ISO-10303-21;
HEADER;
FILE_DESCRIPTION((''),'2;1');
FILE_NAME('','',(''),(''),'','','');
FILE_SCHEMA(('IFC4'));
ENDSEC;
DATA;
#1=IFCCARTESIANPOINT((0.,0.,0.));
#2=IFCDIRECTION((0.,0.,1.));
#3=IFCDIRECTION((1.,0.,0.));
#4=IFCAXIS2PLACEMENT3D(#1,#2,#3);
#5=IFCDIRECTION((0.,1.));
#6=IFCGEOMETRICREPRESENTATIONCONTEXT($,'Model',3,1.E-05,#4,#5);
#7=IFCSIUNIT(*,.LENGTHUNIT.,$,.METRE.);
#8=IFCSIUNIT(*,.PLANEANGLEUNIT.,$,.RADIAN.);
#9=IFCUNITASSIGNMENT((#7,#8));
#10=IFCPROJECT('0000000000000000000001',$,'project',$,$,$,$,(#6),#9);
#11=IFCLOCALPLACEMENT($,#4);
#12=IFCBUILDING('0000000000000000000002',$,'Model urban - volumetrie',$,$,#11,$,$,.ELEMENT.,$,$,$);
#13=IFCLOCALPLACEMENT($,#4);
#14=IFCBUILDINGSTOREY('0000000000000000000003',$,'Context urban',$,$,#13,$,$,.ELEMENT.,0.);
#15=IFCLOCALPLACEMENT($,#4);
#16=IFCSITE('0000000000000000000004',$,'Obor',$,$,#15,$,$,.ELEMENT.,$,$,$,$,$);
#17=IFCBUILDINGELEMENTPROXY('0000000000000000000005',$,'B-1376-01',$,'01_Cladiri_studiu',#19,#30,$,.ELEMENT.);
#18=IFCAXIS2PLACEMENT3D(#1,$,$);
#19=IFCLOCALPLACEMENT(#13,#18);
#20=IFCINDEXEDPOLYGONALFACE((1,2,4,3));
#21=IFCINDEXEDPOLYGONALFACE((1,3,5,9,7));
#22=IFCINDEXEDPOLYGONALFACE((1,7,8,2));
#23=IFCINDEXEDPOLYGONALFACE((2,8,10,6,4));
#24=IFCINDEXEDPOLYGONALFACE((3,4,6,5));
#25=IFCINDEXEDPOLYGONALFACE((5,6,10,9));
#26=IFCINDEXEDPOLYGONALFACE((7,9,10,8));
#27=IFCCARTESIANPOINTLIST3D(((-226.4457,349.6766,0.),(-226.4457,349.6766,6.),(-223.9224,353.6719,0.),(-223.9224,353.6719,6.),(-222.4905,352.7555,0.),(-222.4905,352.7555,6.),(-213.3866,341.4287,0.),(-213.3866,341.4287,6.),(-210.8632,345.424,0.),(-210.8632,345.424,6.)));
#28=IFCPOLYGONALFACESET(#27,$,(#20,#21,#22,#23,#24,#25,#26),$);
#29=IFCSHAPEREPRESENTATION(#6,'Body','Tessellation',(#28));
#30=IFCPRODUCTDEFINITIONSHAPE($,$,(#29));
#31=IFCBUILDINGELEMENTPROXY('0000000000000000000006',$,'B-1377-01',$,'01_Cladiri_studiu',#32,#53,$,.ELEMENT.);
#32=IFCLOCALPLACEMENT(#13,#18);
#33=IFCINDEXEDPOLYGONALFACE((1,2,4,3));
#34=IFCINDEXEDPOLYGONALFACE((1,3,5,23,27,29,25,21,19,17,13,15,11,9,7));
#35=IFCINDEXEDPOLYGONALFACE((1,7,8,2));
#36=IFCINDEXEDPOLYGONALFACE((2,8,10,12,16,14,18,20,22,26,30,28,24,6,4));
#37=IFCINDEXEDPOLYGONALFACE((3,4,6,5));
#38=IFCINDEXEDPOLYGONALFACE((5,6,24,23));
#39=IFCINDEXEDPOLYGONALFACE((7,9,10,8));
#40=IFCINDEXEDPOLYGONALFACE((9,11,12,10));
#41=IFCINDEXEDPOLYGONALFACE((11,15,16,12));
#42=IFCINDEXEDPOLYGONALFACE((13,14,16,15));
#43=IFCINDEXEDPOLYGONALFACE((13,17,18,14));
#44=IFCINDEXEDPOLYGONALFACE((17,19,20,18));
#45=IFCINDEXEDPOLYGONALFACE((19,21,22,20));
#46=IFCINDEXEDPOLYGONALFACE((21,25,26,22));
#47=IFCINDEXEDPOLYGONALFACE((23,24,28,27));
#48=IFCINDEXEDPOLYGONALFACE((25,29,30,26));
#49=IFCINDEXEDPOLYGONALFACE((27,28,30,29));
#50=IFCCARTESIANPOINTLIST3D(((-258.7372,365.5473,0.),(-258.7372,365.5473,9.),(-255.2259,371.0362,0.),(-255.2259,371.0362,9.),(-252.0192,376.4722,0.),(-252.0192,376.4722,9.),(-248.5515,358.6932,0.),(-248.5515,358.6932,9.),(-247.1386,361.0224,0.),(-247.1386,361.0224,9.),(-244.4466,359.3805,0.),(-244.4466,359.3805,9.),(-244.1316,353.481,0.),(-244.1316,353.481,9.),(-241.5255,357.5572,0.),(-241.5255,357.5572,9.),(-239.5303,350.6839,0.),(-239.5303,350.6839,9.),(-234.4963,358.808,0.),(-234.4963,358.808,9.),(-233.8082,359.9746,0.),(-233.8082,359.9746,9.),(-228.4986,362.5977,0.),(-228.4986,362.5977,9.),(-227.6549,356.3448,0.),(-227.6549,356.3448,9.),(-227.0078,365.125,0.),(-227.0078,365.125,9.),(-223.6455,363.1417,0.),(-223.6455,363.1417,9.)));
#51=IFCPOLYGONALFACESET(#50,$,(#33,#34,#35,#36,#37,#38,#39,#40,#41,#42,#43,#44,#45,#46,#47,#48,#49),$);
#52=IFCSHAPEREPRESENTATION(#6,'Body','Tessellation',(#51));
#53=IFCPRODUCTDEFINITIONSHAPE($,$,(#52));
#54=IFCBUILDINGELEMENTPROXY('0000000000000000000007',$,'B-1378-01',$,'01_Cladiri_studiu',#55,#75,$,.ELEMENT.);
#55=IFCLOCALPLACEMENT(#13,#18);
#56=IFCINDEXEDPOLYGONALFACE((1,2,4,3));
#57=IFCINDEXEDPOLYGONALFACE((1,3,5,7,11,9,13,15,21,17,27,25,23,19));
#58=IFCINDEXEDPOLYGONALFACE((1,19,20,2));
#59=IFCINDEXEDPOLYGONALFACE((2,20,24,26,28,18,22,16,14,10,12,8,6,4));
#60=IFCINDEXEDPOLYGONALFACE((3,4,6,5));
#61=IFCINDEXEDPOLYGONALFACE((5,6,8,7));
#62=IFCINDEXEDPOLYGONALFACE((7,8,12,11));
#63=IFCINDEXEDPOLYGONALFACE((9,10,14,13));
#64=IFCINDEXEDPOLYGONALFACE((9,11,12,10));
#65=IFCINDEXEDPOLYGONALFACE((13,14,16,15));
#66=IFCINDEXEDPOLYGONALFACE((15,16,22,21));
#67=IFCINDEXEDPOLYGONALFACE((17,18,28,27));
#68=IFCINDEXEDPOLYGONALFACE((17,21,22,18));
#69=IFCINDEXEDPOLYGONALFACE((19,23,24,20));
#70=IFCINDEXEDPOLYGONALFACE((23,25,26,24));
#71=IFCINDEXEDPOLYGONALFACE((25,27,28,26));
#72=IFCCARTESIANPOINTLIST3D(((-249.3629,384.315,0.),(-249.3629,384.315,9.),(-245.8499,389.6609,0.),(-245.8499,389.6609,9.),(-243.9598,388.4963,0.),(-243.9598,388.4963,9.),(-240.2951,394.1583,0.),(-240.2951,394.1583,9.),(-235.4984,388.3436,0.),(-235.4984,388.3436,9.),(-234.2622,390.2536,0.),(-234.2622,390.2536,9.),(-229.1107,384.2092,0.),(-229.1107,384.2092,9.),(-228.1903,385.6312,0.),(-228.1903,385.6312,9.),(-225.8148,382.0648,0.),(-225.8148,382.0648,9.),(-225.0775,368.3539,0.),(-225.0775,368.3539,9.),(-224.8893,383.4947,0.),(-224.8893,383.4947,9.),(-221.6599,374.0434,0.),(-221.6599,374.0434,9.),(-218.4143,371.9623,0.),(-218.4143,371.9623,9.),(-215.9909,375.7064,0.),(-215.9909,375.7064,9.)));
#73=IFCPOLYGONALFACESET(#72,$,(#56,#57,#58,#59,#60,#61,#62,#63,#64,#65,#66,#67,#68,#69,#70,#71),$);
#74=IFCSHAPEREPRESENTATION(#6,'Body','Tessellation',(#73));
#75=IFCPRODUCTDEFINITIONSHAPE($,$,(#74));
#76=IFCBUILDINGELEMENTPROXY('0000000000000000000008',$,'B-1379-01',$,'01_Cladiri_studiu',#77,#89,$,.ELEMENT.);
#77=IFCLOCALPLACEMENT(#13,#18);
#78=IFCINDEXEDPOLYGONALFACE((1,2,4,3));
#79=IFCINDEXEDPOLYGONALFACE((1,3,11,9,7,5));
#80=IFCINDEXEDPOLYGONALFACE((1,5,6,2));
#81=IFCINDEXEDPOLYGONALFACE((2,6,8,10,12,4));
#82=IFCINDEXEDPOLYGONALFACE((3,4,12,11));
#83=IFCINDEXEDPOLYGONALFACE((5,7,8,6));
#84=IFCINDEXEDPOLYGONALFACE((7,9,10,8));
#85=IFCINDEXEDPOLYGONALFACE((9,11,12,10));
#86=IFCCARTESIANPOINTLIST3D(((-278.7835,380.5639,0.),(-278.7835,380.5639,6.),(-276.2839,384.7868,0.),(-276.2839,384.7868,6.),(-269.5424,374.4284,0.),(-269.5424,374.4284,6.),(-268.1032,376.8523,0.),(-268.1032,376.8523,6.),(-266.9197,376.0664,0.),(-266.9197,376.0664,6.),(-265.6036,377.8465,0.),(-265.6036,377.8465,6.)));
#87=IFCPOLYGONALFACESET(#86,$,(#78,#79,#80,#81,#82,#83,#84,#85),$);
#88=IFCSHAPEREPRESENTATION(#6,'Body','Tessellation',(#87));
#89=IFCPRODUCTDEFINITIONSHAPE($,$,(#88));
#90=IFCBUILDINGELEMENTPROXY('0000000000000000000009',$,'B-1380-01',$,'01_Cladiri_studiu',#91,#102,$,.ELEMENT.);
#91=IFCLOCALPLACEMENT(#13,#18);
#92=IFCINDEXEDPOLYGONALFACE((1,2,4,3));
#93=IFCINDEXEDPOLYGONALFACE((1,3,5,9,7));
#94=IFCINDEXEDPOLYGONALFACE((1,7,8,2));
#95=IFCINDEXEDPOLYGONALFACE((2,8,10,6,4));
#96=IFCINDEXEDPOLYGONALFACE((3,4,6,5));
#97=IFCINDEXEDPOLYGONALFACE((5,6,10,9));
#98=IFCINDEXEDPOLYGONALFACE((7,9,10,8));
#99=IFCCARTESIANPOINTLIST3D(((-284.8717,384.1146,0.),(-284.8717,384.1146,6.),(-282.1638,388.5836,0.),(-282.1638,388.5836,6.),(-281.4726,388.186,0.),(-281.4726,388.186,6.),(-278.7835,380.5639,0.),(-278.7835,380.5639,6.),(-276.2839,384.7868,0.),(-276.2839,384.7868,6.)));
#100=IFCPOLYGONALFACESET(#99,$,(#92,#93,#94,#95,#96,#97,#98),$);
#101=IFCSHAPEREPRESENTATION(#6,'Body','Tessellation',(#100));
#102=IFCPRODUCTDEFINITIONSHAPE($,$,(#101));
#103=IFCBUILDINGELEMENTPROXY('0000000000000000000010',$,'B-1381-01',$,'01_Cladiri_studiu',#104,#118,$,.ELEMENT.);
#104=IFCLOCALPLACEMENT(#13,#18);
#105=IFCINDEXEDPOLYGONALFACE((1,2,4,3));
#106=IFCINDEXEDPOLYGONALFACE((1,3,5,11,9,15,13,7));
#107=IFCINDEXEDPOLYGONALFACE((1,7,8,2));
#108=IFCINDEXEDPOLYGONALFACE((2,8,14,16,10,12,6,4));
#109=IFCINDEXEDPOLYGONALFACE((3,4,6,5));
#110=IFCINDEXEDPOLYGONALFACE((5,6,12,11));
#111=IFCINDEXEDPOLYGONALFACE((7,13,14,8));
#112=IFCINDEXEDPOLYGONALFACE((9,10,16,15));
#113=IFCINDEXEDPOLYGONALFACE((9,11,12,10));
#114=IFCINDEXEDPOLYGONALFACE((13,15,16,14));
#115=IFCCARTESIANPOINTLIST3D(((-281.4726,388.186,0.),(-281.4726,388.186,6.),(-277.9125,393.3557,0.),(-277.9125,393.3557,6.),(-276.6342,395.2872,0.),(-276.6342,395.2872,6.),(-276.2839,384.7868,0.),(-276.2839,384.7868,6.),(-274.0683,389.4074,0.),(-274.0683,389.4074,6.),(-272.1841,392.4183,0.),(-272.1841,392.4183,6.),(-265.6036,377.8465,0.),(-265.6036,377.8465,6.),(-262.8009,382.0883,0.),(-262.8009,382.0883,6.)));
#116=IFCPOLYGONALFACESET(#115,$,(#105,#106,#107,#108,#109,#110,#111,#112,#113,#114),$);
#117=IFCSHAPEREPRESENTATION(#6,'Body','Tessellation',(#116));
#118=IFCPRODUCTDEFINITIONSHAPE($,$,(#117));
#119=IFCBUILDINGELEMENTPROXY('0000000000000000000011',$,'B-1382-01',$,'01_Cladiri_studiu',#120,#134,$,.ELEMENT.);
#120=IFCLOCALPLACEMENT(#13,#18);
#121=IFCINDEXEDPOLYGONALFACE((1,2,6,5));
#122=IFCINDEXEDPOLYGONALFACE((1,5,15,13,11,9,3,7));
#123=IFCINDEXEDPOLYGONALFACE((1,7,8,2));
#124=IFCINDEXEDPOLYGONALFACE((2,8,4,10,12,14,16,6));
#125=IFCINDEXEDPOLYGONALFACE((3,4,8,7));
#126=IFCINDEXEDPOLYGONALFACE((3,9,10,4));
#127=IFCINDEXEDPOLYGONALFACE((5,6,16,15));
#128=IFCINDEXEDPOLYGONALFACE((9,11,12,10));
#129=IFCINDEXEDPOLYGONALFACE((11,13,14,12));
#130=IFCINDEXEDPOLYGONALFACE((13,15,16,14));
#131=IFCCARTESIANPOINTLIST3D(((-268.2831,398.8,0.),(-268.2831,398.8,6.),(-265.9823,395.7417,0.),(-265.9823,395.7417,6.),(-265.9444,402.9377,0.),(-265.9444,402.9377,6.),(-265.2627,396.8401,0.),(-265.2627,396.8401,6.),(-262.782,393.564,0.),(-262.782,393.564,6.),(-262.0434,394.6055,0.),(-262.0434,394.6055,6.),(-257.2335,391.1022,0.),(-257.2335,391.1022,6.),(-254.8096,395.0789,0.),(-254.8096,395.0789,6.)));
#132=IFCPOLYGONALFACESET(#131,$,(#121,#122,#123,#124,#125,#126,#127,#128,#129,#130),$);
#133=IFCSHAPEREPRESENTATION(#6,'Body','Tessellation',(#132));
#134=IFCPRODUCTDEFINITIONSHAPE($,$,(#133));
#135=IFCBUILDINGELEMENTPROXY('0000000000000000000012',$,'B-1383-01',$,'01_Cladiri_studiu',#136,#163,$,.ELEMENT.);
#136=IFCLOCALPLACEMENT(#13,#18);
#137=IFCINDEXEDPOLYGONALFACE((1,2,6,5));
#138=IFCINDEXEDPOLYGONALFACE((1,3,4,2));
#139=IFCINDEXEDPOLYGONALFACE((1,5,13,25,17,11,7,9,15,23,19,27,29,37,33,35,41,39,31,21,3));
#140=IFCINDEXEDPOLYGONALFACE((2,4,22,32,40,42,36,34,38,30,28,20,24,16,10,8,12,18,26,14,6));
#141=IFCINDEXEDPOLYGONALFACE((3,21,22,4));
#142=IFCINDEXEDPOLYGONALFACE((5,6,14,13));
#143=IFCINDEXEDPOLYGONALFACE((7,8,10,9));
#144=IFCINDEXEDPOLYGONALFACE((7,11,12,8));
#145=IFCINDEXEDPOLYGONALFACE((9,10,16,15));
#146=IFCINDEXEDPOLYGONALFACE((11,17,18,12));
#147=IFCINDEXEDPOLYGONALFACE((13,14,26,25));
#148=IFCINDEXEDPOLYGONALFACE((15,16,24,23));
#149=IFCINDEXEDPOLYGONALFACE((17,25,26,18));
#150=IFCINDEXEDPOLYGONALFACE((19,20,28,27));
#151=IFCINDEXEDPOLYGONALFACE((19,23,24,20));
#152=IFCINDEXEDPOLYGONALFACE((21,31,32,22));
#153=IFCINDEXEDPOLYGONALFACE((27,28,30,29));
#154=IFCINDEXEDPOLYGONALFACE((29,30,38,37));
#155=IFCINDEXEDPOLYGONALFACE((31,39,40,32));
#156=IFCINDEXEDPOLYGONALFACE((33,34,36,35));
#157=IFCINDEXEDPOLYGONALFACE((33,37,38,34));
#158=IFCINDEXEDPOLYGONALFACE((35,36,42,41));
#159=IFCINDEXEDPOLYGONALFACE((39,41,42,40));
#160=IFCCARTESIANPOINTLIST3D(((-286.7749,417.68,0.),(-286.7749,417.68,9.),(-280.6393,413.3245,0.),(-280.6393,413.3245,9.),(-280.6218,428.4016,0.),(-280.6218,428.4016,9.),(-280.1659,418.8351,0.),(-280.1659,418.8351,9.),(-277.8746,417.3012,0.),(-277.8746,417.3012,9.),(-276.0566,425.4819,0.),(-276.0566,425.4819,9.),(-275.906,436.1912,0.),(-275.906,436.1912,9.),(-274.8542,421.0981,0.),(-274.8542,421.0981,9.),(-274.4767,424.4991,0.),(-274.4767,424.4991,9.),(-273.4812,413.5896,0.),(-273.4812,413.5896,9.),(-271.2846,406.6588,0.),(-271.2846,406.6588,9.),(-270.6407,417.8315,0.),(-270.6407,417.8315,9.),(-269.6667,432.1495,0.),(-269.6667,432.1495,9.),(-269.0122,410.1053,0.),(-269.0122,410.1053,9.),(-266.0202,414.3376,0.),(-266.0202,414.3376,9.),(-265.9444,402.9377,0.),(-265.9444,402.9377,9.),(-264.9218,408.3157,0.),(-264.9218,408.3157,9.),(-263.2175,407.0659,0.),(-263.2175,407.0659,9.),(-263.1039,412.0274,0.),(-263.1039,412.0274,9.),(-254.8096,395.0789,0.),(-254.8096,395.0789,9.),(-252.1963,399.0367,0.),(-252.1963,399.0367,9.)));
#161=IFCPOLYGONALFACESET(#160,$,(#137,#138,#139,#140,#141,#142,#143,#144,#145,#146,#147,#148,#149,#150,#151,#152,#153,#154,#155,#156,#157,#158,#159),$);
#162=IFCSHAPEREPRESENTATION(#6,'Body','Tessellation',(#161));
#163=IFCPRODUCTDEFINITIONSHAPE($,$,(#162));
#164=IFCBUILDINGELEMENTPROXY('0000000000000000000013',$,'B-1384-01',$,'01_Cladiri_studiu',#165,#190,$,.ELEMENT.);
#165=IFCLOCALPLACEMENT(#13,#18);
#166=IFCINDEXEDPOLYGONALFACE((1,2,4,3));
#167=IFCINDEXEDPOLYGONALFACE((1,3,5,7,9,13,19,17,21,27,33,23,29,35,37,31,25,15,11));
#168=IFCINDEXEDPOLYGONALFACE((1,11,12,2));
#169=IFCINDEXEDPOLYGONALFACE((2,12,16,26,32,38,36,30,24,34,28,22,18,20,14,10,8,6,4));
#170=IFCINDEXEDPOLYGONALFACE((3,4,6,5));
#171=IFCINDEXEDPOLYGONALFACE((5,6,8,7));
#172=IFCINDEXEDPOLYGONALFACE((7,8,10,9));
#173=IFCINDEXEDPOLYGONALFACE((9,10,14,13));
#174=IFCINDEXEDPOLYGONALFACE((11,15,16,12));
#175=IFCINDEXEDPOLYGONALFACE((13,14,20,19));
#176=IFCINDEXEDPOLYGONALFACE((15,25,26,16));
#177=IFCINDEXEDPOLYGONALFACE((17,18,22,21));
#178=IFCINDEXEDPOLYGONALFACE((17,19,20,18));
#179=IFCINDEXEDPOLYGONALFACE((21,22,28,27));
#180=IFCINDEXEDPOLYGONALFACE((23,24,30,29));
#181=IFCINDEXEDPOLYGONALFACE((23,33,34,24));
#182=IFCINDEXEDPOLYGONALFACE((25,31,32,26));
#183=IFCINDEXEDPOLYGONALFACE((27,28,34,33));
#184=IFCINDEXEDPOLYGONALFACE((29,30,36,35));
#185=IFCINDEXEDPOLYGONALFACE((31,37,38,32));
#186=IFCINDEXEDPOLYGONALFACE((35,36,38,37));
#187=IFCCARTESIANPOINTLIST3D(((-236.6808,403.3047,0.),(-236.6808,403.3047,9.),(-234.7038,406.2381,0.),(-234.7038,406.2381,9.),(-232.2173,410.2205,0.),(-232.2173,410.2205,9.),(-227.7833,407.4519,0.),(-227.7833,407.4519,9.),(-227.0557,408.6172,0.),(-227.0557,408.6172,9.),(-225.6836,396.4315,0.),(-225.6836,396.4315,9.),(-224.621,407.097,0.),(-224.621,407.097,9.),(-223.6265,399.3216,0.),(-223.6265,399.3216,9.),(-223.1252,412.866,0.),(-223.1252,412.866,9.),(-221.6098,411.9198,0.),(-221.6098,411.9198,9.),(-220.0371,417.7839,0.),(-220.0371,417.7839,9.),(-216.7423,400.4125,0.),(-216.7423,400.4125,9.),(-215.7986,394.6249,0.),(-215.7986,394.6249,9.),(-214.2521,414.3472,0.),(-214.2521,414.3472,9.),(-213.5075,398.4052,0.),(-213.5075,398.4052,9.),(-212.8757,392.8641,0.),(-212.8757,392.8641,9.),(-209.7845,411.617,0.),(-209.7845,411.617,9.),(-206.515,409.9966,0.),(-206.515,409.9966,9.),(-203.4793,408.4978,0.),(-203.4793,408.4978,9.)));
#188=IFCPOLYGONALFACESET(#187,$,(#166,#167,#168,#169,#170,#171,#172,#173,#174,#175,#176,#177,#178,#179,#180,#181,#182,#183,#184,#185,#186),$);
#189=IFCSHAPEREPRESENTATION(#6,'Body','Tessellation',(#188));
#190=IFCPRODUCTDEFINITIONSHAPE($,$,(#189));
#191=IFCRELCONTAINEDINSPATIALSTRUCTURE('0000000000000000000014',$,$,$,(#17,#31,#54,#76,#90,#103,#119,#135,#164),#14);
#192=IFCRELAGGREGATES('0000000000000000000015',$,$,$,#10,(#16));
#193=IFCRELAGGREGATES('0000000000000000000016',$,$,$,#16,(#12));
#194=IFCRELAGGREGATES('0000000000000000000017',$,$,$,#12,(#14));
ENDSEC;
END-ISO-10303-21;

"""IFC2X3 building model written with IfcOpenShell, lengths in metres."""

from ifc_helpers import new_model, si_unit, direction, origin_with_axes, place, context, project, spatial, polyline, outline, extrude, element, save


model = new_model("IFC2X3")

# Units and contexts
model_context = context("Model", 3, precision=1e-05, world=origin_with_axes(), true_north=direction((0.0, 1.0)))
ifc_project = project(units=[si_unit("LENGTHUNIT", "METRE"), si_unit("PLANEANGLEUNIT", "RADIAN")], contexts=[model_context])

# Site, building, storey
site_placement = place(None, origin_with_axes())
site = spatial("IfcSite", under=ifc_project, at=site_placement, Name="Obor", CompositionType="ELEMENT")
building_placement = place(None, origin_with_axes())
building = spatial("IfcBuilding", under=site, at=building_placement, Name="Model urban - volumetrie", CompositionType="ELEMENT")
storey_placement = place(None, origin_with_axes())
storey = spatial("IfcBuildingStorey", under=building, at=storey_placement, Name="Context urban", CompositionType="ELEMENT", Elevation=0.0)

# Building element proxies
proxy_1_placement = place(None, origin_with_axes())
element("IfcBuildingElementProxy", 1, at=proxy_1_placement, inside=storey, Name="B-1376-01", ObjectType="01_Cladiri_studiu", CompositionType="ELEMENT", context=model_context, shape_type="SweptSolid", body=[
    extrude(outline(polyline([(-226.4457, 349.6766), (-213.3866, 341.4287), (-210.8632, 345.424), (-222.4905, 352.7555), (-223.9224, 353.6719), (-226.4457, 349.6766)])), origin_with_axes(), (0.0, 0.0, 1.0), 6.0),
])
proxy_2_placement = place(None, origin_with_axes())
element("IfcBuildingElementProxy", 2, at=proxy_2_placement, inside=storey, Name="B-1377-01", ObjectType="01_Cladiri_studiu", CompositionType="ELEMENT", context=model_context, shape_type="SweptSolid", body=[
    extrude(outline(polyline([(-223.6455, 363.1417), (-227.0078, 365.125), (-228.4986, 362.5977), (-252.0192, 376.4722), (-255.2259, 371.0362), (-258.7372, 365.5473), (-248.5515, 358.6932), (-247.1386, 361.0224), (-244.4466, 359.3805), (-241.5255, 357.5572), (-244.1316, 353.481), (-239.5303, 350.6839), (-234.4963, 358.808), (-233.8082, 359.9746), (-227.6549, 356.3448), (-223.6455, 363.1417)]), holes=[polyline([(-246.2195, 365.7234), (-255.2259, 371.0362), (-246.2195, 365.7234), (-242.1078, 363.2753), (-246.2195, 365.7234)])]), origin_with_axes(), (0.0, 0.0, 1.0), 9.0),
])
proxy_3_placement = place(None, origin_with_axes())
element("IfcBuildingElementProxy", 3, at=proxy_3_placement, inside=storey, Name="B-1378-01", ObjectType="01_Cladiri_studiu", CompositionType="ELEMENT", context=model_context, shape_type="SweptSolid", body=[
    extrude(outline(polyline([(-225.8148, 382.0648), (-224.8893, 383.4947), (-228.1903, 385.6312), (-229.1107, 384.2092), (-235.4984, 388.3436), (-234.2622, 390.2536), (-240.2951, 394.1583), (-243.9598, 388.4963), (-245.8499, 389.6609), (-249.3629, 384.315), (-225.0775, 368.3539), (-221.6599, 374.0434), (-218.4143, 371.9623), (-215.9909, 375.7064), (-225.8148, 382.0648)])), origin_with_axes(), (0.0, 0.0, 1.0), 9.0),
])
proxy_4_placement = place(None, origin_with_axes())
element("IfcBuildingElementProxy", 4, at=proxy_4_placement, inside=storey, Name="B-1379-01", ObjectType="01_Cladiri_studiu", CompositionType="ELEMENT", context=model_context, shape_type="SweptSolid", body=[
    extrude(outline(polyline([(-266.9197, 376.0664), (-265.6036, 377.8465), (-276.2839, 384.7868), (-278.7835, 380.5639), (-269.5424, 374.4284), (-268.1032, 376.8523), (-266.9197, 376.0664)])), origin_with_axes(), (0.0, 0.0, 1.0), 6.0),
])
proxy_5_placement = place(None, origin_with_axes())
element("IfcBuildingElementProxy", 5, at=proxy_5_placement, inside=storey, Name="B-1380-01", ObjectType="01_Cladiri_studiu", CompositionType="ELEMENT", context=model_context, shape_type="SweptSolid", body=[
    extrude(outline(polyline([(-284.8717, 384.1146), (-278.7835, 380.5639), (-276.2839, 384.7868), (-281.4726, 388.186), (-282.1638, 388.5836), (-284.8717, 384.1146)])), origin_with_axes(), (0.0, 0.0, 1.0), 6.0),
])
proxy_6_placement = place(None, origin_with_axes())
element("IfcBuildingElementProxy", 6, at=proxy_6_placement, inside=storey, Name="B-1381-01", ObjectType="01_Cladiri_studiu", CompositionType="ELEMENT", context=model_context, shape_type="SweptSolid", body=[
    extrude(outline(polyline([(-281.4726, 388.186), (-276.2839, 384.7868), (-265.6036, 377.8465), (-262.8009, 382.0883), (-274.0683, 389.4074), (-272.1841, 392.4183), (-276.6342, 395.2872), (-277.9125, 393.3557), (-281.4726, 388.186)])), origin_with_axes(), (0.0, 0.0, 1.0), 6.0),
])
proxy_7_placement = place(None, origin_with_axes())
element("IfcBuildingElementProxy", 7, at=proxy_7_placement, inside=storey, Name="B-1382-01", ObjectType="01_Cladiri_studiu", CompositionType="ELEMENT", context=model_context, shape_type="SweptSolid", body=[
    extrude(outline(polyline([(-265.2627, 396.8401), (-265.9823, 395.7417), (-262.782, 393.564), (-262.0434, 394.6055), (-257.2335, 391.1022), (-254.8096, 395.0789), (-265.9444, 402.9377), (-268.2831, 398.8), (-265.2627, 396.8401)])), origin_with_axes(), (0.0, 0.0, 1.0), 6.0),
])
proxy_8_placement = place(None, origin_with_axes())
element("IfcBuildingElementProxy", 8, at=proxy_8_placement, inside=storey, Name="B-1383-01", ObjectType="01_Cladiri_studiu", CompositionType="ELEMENT", context=model_context, shape_type="SweptSolid", body=[
    extrude(outline(polyline([(-280.6218, 428.4016), (-286.7749, 417.68), (-280.6393, 413.3245), (-271.2846, 406.6588), (-265.9444, 402.9377), (-254.8096, 395.0789), (-252.1963, 399.0367), (-263.2175, 407.0659), (-264.9218, 408.3157), (-263.1039, 412.0274), (-266.0202, 414.3376), (-269.0122, 410.1053), (-273.4812, 413.5896), (-270.6407, 417.8315), (-274.8542, 421.0981), (-277.8746, 417.3012), (-280.1659, 418.8351), (-276.0566, 425.4819), (-274.4767, 424.4991), (-269.6667, 432.1495), (-275.906, 436.1912), (-280.6218, 428.4016)])), origin_with_axes(), (0.0, 0.0, 1.0), 9.0),
])
proxy_9_placement = place(None, origin_with_axes())
element("IfcBuildingElementProxy", 9, at=proxy_9_placement, inside=storey, Name="B-1384-01", ObjectType="01_Cladiri_studiu", CompositionType="ELEMENT", context=model_context, shape_type="SweptSolid", body=[
    extrude(outline(polyline([(-213.5075, 398.4052), (-216.7423, 400.4125), (-209.7845, 411.617), (-214.2521, 414.3472), (-220.0371, 417.7839), (-223.1252, 412.866), (-221.6098, 411.9198), (-224.621, 407.097), (-227.0557, 408.6172), (-227.7833, 407.4519), (-232.2173, 410.2205), (-234.7038, 406.2381), (-236.6808, 403.3047), (-225.6836, 396.4315), (-223.6265, 399.3216), (-215.7986, 394.6249), (-212.8757, 392.8641), (-203.4793, 408.4978), (-206.515, 409.9966), (-213.5075, 398.4052)])), origin_with_axes(), (0.0, 0.0, 1.0), 9.0),
])

save(model, "model.ifc")
